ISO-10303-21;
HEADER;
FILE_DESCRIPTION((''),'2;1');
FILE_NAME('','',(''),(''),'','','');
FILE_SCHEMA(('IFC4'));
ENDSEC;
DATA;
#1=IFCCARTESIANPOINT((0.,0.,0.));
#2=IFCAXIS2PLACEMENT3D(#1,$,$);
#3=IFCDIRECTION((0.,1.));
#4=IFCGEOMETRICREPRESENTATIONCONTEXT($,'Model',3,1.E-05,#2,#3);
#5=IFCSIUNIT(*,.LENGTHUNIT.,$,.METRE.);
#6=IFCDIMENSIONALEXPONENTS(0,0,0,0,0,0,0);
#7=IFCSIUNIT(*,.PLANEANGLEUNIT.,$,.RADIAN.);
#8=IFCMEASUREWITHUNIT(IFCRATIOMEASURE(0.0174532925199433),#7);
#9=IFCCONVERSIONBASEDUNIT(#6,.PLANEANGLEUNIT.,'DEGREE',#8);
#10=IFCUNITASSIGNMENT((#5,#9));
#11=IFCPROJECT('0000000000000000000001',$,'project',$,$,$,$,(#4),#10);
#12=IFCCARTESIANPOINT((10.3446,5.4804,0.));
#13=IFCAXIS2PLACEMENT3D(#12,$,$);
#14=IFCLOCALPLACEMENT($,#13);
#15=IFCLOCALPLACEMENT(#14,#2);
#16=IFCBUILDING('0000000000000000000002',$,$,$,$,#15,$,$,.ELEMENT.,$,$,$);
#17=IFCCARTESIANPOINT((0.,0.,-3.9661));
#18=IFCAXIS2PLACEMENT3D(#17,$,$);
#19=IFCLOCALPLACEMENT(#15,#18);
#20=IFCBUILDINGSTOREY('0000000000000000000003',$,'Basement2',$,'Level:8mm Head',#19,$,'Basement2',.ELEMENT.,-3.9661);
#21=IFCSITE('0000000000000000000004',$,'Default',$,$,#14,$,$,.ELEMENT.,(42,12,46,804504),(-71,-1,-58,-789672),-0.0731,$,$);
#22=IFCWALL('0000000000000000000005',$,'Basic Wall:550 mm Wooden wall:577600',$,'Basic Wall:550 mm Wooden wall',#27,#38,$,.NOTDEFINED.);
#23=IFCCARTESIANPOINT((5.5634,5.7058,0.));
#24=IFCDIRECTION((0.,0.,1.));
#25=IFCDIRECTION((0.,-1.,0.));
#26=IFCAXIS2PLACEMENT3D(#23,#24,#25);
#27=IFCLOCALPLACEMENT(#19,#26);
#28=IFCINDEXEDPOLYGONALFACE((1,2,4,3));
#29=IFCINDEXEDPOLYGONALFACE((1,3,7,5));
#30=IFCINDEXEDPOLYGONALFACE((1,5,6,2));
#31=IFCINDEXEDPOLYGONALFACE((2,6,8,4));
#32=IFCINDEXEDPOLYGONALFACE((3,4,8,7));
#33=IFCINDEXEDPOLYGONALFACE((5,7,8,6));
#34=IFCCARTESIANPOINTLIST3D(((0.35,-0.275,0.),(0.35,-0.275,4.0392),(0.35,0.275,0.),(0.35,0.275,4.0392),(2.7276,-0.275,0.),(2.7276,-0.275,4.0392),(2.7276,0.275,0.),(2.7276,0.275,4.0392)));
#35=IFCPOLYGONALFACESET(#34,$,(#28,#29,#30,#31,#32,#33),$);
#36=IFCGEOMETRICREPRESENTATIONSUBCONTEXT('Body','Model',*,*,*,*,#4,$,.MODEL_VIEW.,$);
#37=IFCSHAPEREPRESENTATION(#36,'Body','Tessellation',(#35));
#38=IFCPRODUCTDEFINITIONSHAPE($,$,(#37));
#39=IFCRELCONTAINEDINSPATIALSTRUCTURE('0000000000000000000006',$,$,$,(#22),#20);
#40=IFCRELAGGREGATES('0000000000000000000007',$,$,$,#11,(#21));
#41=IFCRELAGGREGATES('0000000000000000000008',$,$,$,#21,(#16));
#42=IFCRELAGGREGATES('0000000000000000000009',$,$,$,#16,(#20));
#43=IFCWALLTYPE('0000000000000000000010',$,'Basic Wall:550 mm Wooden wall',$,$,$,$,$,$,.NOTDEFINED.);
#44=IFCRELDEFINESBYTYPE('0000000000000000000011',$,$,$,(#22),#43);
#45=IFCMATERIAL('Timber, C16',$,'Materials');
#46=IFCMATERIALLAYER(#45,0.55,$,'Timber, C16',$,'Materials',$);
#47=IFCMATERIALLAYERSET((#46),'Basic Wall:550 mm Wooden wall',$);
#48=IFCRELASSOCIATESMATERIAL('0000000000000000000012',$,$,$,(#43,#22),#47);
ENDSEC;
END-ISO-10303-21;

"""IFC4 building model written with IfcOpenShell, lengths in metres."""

from ifc_helpers import new_model, entity, si_unit, converted_unit, direction, frame, frame_2d, origin, place, context, subcontext, project, spatial, rectangle, extrude, material, layer, layer_set, layer_usage, type_object, element, save


model = new_model("IFC4")

# Units and contexts
model_context = context("Model", 3, precision=1e-05, world=origin(), true_north=direction((0.0, 1.0)))
body_context = subcontext(model_context, "Body", "Model", "MODEL_VIEW")
ifc_project = project(units=[si_unit("LENGTHUNIT", "METRE"), converted_unit("PLANEANGLEUNIT", "DEGREE", entity("IfcRatioMeasure", 0.0174532925199433), si_unit("PLANEANGLEUNIT", "RADIAN"), dimensions=[0, 0, 0, 0, 0, 0, 0])], contexts=[model_context])

# Site, building, storey
site_placement = place(None, frame((10.3446, 5.4804, 0.0)))
site = spatial("IfcSite", under=ifc_project, at=site_placement, Name="Default", CompositionType="ELEMENT", RefLatitude=(42, 12, 46, 804504), RefLongitude=(-71, -1, -58, -789672), RefElevation=-0.0731)
building_placement = place(site_placement, origin())
building = spatial("IfcBuilding", under=site, at=building_placement, CompositionType="ELEMENT")
storey_placement = place(building_placement, frame((0.0, 0.0, -3.9661)))
storey = spatial("IfcBuildingStorey", under=building, at=storey_placement, Name="Basement2", ObjectType="Level:8mm Head", LongName="Basement2", CompositionType="ELEMENT", Elevation=-3.9661)

# Wall
ifc_material_1 = material(Name="Timber, C16", Category="Materials")
ifc_layer_1 = layer(ifc_material_1, 0.55, Name="Timber, C16", Category="Materials")
ifc_layer_set_1 = layer_set([ifc_layer_1], Name="Basic Wall:550 mm Wooden wall")
ifc_layer_usage_1 = layer_usage(ifc_layer_set_1, "AXIS2", "NEGATIVE", 0.275)
wall_type_1 = type_object("IfcWallType", Name="Basic Wall:550 mm Wooden wall", PredefinedType="NOTDEFINED", material=ifc_layer_set_1)
wall_1_placement = place(storey_placement, frame((5.5634, 5.7058, 0.0), z_axis=(0.0, 0.0, 1.0), x_axis=(0.0, -1.0, 0.0)))
element("IfcWall", 1, at=wall_1_placement, inside=storey, type_object=wall_type_1, material=ifc_layer_usage_1, Name="Basic Wall:550 mm Wooden wall:577600", ObjectType="Basic Wall:550 mm Wooden wall", PredefinedType="NOTDEFINED", context=body_context, shape_type="SweptSolid", body=[
    extrude(rectangle(XDim=2.3776, YDim=0.55, at=frame_2d((1.5388, 0.0), x_axis=(-1.0, 0.0))), origin(), (0.0, 0.0, 1.0), 4.0392),
])

save(model, "model.ifc")
